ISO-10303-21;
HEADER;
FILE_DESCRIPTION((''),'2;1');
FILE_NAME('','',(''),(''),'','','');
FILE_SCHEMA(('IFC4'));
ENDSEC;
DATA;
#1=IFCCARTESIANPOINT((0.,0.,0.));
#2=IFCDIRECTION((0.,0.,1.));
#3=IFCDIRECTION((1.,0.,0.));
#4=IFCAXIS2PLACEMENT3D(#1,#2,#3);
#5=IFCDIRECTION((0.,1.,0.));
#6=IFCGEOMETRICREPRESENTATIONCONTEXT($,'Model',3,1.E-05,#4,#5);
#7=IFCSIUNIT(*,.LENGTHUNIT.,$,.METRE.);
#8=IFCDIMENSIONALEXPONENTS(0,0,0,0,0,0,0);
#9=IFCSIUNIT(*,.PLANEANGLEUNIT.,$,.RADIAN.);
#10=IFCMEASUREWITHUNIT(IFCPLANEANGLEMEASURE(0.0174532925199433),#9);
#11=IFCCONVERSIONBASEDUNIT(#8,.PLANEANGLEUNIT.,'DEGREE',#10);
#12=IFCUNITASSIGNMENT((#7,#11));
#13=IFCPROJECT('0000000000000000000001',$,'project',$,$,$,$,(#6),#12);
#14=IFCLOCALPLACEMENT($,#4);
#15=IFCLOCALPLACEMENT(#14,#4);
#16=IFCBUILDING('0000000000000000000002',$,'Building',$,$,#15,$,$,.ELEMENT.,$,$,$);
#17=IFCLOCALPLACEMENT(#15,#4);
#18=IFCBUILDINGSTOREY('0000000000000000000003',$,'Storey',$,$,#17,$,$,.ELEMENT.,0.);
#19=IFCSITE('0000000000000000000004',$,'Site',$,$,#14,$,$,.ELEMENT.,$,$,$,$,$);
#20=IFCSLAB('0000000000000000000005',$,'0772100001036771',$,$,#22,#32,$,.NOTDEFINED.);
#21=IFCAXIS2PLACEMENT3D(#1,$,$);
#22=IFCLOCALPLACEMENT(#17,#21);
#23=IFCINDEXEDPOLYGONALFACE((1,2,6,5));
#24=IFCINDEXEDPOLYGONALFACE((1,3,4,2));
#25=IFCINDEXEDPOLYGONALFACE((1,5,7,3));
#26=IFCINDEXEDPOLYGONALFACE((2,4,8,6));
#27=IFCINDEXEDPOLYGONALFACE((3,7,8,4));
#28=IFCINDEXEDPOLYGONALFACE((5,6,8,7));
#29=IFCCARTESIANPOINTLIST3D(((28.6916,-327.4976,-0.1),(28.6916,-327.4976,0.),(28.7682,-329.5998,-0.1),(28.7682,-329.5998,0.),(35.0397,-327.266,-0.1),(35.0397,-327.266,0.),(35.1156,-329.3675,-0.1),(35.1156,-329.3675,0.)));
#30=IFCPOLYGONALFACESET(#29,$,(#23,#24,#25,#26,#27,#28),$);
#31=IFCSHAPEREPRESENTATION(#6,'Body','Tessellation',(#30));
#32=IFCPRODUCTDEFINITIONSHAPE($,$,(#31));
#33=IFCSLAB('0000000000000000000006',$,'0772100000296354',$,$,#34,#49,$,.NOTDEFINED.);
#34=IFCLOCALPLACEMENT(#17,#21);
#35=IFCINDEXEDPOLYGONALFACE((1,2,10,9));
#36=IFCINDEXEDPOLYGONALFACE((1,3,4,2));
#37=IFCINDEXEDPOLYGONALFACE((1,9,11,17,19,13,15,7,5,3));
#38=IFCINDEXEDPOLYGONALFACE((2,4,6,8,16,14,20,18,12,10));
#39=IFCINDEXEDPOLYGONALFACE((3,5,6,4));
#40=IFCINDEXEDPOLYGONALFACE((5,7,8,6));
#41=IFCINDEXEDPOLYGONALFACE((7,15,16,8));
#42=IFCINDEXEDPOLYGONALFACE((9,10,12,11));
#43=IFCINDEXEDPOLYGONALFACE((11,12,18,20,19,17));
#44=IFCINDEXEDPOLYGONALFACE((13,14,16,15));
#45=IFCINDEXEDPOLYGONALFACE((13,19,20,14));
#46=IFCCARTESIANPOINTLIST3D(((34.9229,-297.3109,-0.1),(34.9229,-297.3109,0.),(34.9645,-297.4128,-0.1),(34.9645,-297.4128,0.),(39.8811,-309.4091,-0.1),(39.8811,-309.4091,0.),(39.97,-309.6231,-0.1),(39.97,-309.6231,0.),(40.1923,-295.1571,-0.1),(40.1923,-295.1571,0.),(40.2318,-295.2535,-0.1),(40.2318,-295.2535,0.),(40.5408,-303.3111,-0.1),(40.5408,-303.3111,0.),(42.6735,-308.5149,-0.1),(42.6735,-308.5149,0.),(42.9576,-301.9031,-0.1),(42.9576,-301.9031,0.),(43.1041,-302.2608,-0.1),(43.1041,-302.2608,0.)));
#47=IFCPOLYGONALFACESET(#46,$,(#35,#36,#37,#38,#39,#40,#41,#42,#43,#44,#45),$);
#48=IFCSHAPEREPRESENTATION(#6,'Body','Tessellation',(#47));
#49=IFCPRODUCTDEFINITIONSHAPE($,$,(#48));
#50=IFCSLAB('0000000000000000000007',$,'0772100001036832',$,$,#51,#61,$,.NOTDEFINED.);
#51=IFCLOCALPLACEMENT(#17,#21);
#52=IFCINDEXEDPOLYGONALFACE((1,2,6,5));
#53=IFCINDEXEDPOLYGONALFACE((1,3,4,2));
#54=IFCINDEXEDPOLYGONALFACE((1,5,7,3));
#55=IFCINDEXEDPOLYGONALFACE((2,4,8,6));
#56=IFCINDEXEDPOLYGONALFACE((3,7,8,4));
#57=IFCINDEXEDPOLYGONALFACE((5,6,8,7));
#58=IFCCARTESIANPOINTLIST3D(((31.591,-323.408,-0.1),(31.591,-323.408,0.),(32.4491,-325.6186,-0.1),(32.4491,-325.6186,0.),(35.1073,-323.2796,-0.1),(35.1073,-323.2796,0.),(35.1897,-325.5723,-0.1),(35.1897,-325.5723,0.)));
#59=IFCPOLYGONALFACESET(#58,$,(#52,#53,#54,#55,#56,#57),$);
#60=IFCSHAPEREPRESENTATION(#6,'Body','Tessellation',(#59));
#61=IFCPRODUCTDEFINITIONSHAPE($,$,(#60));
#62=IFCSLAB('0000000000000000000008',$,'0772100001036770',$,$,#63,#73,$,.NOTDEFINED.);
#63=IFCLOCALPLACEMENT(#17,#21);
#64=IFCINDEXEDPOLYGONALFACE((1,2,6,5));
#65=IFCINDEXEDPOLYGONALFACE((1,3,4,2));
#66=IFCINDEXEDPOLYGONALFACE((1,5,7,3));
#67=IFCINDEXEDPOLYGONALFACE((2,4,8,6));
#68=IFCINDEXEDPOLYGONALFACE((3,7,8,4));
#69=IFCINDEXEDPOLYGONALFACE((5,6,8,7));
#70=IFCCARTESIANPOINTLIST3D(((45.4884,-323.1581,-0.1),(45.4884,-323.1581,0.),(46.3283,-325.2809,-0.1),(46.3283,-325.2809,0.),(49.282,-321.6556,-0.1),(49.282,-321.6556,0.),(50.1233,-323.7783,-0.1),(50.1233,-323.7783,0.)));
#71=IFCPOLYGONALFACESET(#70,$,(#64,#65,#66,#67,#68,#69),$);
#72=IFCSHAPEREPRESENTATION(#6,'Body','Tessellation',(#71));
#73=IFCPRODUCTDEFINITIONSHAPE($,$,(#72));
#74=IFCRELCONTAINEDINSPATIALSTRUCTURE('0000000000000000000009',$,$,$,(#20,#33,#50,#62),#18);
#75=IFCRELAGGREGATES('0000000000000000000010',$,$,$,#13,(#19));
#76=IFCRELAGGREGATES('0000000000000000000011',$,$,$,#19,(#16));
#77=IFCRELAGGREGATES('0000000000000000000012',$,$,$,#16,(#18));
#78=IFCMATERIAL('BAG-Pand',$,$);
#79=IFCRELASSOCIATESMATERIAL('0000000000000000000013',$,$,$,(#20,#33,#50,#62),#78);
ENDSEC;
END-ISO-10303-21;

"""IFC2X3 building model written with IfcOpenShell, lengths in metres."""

from ifc_helpers import new_model, entity, si_unit, converted_unit, direction, frame, origin_with_axes, place, context, project, spatial, polyline, outline, extrude, material, element, save


model = new_model("IFC2X3")

# Units and contexts
model_context = context("Model", 3, precision=1e-05, world=origin_with_axes(), true_north=direction((0.0, 1.0, 0.0)))
ifc_project = project(units=[si_unit("LENGTHUNIT", "METRE"), converted_unit("PLANEANGLEUNIT", "DEGREE", entity("IfcPlaneAngleMeasure", 0.0174532925199433), si_unit("PLANEANGLEUNIT", "RADIAN"), dimensions=[0, 0, 0, 0, 0, 0, 0])], contexts=[model_context])

# Site, building, storey
site_placement = place(None, origin_with_axes())
site = spatial("IfcSite", under=ifc_project, at=site_placement, Name="Site", CompositionType="ELEMENT")
building_placement = place(site_placement, origin_with_axes())
building = spatial("IfcBuilding", under=site, at=building_placement, Name="Building", CompositionType="ELEMENT")
storey_placement = place(building_placement, origin_with_axes())
storey = spatial("IfcBuildingStorey", under=building, at=storey_placement, Name="Storey", CompositionType="ELEMENT", Elevation=0.0)

# Slabs
ifc_material = material(Name="BAG-Pand")
slab_1_placement = place(storey_placement, frame((0.0, 0.0, -0.1), z_axis=(0.0, 0.0, 1.0), x_axis=(1.0, 0.0, 0.0)))
element("IfcSlab", 1, at=slab_1_placement, inside=storey, material=ifc_material, Name="0772100001036771", PredefinedType="NOTDEFINED", context=model_context, shape_type="SweptSolid", body=[
    extrude(outline(polyline([(28.6916, -327.4976), (35.0397, -327.266), (35.1156, -329.3675), (28.7682, -329.5998), (28.6916, -327.4976)])), origin_with_axes(), (0.0, 0.0, 1.0), 0.1),
])
slab_2_placement = place(storey_placement, frame((0.0, 0.0, -0.1), z_axis=(0.0, 0.0, 1.0), x_axis=(1.0, 0.0, 0.0)))
element("IfcSlab", 2, at=slab_2_placement, inside=storey, material=ifc_material, Name="0772100000296354", PredefinedType="NOTDEFINED", context=model_context, shape_type="SweptSolid", body=[
    extrude(outline(polyline([(39.97, -309.6231), (39.8811, -309.4091), (34.9645, -297.4128), (34.9229, -297.3109), (40.1923, -295.1571), (40.2318, -295.2535), (42.9576, -301.9031), (43.1041, -302.2608), (40.5408, -303.3111), (42.6735, -308.5149), (39.97, -309.6231)])), origin_with_axes(), (0.0, 0.0, 1.0), 0.1),
])
slab_3_placement = place(storey_placement, frame((0.0, 0.0, -0.1), z_axis=(0.0, 0.0, 1.0), x_axis=(1.0, 0.0, 0.0)))
element("IfcSlab", 3, at=slab_3_placement, inside=storey, material=ifc_material, Name="0772100001036832", PredefinedType="NOTDEFINED", context=model_context, shape_type="SweptSolid", body=[
    extrude(outline(polyline([(31.591, -323.408), (35.1073, -323.2796), (35.1897, -325.5723), (32.4491, -325.6186), (31.591, -323.408)])), origin_with_axes(), (0.0, 0.0, 1.0), 0.1),
])
slab_4_placement = place(storey_placement, frame((0.0, 0.0, -0.1), z_axis=(0.0, 0.0, 1.0), x_axis=(1.0, 0.0, 0.0)))
element("IfcSlab", 4, at=slab_4_placement, inside=storey, material=ifc_material, Name="0772100001036770", PredefinedType="NOTDEFINED", context=model_context, shape_type="SweptSolid", body=[
    extrude(outline(polyline([(45.4884, -323.1581), (49.282, -321.6556), (50.1233, -323.7783), (46.3283, -325.2809), (45.4884, -323.1581)])), origin_with_axes(), (0.0, 0.0, 1.0), 0.1),
])

save(model, "model.ifc")
